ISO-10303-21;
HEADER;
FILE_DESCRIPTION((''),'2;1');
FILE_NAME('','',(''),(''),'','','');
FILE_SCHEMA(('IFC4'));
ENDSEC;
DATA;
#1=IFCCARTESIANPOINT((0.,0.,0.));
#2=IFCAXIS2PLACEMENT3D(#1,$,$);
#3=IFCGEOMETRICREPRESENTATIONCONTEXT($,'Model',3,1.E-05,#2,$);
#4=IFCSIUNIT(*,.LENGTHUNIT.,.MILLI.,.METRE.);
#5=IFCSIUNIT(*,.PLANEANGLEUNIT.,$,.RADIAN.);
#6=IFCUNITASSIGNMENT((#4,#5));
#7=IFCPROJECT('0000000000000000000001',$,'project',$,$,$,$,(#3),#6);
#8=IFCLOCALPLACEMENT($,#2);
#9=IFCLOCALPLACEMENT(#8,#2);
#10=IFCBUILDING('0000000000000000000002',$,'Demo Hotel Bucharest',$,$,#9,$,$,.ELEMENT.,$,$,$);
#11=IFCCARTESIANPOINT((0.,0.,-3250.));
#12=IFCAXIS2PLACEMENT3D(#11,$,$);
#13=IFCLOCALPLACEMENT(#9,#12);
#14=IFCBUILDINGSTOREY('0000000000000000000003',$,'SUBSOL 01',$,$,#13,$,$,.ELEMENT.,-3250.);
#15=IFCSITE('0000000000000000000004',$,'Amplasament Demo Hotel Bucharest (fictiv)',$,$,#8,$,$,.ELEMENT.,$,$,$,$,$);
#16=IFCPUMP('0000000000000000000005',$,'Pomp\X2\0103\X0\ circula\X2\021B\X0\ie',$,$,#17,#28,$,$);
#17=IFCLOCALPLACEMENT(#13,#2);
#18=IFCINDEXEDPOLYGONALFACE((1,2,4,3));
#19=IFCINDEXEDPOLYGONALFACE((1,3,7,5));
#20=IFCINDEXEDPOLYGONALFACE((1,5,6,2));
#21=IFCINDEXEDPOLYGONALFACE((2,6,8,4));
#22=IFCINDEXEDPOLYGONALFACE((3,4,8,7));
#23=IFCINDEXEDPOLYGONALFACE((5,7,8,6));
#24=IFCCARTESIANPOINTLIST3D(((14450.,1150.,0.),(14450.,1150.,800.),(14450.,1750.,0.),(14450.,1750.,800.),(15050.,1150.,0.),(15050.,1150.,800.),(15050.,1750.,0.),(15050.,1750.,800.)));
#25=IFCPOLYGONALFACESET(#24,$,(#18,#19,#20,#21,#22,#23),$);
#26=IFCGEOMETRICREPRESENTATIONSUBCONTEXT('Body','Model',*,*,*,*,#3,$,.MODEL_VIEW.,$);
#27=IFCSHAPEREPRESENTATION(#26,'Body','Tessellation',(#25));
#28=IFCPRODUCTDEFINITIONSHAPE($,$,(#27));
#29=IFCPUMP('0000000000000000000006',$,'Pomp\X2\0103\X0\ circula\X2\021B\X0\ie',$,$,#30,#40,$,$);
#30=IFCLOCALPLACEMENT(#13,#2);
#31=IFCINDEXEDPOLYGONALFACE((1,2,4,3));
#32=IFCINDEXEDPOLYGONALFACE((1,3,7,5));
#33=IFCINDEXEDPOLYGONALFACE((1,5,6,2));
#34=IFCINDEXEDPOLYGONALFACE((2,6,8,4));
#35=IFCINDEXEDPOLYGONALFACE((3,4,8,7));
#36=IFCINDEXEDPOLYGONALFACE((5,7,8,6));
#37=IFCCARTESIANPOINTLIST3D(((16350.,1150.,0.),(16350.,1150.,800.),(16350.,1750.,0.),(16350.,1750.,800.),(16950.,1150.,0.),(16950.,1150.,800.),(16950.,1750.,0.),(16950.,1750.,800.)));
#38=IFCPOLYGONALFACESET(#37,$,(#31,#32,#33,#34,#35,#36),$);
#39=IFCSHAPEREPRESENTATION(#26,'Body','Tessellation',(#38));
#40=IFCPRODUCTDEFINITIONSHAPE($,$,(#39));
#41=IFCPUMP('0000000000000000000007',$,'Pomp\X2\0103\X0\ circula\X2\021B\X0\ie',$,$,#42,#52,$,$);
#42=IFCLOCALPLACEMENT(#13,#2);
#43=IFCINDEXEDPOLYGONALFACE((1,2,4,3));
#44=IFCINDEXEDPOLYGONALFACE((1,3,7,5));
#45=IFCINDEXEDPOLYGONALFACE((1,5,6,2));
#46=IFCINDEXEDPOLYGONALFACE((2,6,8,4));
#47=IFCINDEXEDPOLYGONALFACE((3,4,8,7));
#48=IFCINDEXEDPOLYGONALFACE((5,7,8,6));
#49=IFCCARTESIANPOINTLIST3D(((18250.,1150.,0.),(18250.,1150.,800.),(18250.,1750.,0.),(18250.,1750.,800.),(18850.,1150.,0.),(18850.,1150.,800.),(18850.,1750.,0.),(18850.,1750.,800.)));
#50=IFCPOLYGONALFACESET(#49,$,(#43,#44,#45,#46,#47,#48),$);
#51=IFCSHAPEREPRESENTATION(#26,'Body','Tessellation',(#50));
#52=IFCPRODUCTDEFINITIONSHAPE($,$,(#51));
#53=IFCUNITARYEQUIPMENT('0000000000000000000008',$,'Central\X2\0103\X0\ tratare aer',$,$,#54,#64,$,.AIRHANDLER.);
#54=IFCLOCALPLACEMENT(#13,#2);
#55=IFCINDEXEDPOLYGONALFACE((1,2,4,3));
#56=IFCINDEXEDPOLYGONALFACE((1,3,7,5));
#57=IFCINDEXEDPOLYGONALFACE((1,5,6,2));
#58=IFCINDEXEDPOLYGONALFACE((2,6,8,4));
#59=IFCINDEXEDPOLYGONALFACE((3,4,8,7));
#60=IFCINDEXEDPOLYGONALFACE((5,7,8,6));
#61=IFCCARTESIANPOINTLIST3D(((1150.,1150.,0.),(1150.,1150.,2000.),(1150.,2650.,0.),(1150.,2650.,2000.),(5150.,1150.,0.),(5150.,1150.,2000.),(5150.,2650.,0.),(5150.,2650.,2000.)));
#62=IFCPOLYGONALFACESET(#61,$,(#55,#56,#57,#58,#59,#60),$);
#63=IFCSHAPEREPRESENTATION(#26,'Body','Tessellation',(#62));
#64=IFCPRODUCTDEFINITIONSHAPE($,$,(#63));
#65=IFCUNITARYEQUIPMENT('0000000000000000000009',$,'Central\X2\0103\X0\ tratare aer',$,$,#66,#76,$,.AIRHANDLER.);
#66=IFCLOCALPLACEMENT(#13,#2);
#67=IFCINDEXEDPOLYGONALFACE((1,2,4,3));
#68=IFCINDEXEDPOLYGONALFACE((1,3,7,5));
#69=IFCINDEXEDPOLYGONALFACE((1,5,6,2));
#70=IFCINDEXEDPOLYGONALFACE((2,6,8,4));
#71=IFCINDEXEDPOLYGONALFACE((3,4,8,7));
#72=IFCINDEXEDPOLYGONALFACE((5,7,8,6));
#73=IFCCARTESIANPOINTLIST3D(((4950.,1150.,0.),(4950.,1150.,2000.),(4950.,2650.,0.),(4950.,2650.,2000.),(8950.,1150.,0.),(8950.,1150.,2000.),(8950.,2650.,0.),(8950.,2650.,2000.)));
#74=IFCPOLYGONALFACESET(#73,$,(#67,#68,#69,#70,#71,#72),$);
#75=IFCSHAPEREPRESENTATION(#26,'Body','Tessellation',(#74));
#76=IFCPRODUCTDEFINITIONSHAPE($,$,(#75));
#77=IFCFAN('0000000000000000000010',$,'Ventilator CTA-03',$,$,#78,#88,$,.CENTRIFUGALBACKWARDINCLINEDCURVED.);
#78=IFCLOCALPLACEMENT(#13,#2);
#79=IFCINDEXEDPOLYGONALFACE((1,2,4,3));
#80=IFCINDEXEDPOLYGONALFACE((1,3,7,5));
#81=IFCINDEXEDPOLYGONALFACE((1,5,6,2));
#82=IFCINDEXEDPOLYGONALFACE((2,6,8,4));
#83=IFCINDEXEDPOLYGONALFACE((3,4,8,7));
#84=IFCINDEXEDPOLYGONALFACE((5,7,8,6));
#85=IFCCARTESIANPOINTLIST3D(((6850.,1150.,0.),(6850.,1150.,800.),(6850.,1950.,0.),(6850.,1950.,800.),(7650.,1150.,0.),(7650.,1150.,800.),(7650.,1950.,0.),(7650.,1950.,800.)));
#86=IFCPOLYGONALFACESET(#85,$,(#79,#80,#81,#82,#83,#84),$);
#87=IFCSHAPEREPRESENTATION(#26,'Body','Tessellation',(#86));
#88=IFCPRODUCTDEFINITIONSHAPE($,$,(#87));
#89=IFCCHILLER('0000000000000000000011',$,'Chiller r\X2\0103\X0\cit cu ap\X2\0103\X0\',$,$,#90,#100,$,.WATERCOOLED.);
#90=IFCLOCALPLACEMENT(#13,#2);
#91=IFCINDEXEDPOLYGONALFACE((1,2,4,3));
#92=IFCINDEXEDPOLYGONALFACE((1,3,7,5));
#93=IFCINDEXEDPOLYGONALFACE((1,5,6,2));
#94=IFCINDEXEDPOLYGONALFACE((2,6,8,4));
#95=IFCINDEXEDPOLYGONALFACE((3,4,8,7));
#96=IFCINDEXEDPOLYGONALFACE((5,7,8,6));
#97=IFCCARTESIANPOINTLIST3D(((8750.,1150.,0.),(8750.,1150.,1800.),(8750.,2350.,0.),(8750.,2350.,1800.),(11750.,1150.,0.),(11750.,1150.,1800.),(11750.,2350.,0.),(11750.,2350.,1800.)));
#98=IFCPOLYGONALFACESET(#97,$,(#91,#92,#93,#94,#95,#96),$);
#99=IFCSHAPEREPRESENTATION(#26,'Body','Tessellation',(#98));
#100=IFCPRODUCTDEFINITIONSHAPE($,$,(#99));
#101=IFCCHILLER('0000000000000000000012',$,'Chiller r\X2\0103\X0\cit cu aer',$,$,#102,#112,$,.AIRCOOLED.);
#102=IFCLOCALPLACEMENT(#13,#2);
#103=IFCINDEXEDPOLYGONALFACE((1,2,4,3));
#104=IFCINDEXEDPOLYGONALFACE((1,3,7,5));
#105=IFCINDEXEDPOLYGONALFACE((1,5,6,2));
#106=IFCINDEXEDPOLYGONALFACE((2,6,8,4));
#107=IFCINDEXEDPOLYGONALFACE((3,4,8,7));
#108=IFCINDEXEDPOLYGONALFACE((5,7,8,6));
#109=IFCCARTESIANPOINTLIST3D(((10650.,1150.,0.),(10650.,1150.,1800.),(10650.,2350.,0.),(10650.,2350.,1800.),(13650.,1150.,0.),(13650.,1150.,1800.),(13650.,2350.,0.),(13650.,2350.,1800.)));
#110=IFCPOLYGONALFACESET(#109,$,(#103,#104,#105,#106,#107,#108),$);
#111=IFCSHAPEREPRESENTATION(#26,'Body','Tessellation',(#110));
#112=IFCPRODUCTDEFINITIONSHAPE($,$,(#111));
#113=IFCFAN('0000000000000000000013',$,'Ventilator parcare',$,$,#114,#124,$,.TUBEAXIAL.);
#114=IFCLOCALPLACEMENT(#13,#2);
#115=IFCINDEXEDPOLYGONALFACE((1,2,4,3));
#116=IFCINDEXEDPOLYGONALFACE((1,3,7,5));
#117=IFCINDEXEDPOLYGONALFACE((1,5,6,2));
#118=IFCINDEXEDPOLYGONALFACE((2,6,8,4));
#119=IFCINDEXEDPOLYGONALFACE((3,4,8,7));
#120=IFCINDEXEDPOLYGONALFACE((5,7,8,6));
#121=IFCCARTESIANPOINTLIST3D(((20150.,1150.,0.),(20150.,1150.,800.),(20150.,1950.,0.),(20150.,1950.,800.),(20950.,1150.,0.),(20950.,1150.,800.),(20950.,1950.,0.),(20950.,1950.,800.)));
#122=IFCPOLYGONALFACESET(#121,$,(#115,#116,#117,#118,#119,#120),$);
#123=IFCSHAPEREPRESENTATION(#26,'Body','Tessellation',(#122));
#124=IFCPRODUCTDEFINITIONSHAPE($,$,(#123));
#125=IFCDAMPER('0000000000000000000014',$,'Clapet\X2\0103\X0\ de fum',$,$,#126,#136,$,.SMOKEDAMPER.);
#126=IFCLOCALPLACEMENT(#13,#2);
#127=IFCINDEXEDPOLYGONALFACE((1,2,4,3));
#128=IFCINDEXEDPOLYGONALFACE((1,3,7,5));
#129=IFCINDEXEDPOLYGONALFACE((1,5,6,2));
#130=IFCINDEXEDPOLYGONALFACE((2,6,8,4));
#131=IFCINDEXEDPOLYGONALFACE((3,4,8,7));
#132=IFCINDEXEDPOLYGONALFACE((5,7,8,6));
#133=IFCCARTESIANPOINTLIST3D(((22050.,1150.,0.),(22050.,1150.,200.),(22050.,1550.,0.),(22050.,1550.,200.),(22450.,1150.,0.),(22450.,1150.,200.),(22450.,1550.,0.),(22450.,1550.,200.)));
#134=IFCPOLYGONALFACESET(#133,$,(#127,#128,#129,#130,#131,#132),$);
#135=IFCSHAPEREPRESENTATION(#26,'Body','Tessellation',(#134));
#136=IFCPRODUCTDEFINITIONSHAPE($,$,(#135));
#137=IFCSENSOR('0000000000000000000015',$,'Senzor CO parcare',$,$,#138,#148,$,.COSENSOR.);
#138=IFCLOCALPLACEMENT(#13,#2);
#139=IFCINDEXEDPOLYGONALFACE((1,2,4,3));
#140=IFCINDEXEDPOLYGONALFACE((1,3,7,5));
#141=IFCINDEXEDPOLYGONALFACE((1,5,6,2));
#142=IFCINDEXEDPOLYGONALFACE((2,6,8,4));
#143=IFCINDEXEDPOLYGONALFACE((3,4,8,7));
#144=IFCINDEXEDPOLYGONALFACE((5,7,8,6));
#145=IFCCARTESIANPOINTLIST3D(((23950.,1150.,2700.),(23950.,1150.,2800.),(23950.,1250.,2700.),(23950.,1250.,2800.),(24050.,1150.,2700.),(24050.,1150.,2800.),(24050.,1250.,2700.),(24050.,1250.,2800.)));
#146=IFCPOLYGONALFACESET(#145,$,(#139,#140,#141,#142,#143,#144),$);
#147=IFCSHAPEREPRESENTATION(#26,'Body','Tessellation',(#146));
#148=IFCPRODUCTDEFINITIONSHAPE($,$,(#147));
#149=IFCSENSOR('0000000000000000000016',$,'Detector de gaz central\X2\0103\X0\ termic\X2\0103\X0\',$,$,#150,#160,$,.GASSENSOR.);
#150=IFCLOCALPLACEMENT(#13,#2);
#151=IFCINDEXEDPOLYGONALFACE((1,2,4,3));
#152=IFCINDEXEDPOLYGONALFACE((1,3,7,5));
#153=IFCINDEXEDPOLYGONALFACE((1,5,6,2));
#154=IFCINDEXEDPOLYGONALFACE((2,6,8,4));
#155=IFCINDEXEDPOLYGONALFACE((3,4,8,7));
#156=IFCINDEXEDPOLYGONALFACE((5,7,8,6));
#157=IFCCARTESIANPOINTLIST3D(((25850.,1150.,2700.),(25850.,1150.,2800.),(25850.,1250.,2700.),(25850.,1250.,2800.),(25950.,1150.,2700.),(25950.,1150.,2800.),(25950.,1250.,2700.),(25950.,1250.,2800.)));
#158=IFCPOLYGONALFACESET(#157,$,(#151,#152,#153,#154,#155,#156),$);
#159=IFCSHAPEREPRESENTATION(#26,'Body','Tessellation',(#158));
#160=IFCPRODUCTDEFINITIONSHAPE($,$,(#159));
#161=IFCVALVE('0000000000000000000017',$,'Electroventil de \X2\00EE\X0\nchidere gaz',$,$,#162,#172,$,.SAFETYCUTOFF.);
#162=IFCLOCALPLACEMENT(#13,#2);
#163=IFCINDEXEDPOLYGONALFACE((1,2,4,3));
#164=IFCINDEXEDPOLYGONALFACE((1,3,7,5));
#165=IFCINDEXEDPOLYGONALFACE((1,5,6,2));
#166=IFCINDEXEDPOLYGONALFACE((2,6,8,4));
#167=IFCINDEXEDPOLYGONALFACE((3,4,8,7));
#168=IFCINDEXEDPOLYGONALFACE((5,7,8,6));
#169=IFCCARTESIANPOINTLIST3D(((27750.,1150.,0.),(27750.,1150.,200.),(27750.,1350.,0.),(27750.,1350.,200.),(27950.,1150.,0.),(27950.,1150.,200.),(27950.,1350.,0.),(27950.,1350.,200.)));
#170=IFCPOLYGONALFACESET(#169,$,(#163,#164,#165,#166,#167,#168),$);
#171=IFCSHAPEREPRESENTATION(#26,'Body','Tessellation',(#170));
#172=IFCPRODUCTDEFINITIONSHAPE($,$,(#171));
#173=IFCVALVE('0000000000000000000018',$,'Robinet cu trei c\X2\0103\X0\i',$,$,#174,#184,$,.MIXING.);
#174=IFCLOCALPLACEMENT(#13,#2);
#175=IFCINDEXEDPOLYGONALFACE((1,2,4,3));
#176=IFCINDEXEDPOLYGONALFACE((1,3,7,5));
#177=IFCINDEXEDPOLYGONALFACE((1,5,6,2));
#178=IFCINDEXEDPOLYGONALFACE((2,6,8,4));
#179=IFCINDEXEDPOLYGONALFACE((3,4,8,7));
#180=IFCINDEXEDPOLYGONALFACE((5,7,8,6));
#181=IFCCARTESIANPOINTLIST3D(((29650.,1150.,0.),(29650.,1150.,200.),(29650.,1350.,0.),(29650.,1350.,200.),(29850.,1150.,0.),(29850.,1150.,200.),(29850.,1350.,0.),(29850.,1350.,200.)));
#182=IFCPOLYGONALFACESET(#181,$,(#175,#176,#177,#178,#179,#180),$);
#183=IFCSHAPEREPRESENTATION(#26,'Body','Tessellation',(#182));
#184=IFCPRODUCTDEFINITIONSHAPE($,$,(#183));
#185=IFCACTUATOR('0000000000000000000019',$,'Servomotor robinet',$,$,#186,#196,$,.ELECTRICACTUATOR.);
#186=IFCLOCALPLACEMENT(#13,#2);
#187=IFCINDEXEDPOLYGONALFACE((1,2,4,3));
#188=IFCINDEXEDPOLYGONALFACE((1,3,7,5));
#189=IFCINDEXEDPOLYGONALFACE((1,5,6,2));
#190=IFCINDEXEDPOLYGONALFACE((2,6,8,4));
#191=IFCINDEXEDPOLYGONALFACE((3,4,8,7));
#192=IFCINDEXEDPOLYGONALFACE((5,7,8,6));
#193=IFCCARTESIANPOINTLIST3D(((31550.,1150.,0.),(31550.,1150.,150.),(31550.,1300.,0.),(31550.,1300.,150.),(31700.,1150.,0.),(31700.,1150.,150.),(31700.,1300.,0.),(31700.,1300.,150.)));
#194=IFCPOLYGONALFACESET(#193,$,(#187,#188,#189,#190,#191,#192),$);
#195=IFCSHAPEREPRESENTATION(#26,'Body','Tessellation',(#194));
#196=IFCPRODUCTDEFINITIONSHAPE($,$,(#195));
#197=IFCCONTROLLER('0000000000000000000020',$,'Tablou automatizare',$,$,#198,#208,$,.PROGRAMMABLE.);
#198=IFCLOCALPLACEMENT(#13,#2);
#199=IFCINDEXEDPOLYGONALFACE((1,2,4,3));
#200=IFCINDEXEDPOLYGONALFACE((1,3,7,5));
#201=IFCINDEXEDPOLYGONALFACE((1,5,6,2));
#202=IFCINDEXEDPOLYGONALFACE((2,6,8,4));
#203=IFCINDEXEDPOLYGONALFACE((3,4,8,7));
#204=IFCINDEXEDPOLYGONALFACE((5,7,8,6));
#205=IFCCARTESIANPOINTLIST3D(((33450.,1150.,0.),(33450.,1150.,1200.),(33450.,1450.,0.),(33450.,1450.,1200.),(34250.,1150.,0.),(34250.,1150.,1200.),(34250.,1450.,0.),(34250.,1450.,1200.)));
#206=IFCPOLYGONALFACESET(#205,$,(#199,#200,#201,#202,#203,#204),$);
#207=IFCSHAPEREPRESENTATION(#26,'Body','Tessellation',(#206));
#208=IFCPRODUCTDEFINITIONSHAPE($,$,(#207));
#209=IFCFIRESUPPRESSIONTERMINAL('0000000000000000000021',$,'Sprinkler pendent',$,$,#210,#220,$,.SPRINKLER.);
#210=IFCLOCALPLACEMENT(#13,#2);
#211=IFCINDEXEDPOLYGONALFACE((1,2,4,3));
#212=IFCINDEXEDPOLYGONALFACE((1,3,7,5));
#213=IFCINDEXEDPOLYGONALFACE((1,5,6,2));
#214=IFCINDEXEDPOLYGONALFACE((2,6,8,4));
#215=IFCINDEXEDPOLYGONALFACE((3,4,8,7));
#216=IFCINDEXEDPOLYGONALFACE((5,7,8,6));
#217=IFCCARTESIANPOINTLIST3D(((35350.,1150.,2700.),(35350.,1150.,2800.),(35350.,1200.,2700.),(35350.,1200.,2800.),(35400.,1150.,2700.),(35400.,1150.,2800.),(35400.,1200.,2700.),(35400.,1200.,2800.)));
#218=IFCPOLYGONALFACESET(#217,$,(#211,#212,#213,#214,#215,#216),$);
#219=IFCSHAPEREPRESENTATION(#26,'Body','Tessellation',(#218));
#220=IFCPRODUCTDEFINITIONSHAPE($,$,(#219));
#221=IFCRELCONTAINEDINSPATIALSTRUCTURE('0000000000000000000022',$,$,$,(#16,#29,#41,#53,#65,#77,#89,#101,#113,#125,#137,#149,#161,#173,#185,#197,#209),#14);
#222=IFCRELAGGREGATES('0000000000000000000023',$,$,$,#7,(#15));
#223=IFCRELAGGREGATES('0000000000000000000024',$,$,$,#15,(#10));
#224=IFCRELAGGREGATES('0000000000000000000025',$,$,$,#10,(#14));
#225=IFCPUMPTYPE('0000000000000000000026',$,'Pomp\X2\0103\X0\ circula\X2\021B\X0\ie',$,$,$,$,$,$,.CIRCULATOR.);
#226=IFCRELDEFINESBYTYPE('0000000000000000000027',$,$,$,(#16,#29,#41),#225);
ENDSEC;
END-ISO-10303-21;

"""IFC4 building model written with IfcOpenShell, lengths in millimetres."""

from ifc_helpers import new_model, si_unit, frame, frame_2d, origin, place, context, subcontext, project, spatial, rectangle, extrude, type_object, element, save


model = new_model("IFC4")

# Units and contexts
model_context = context("Model", 3, precision=1e-05, world=origin())
body_context = subcontext(model_context, "Body", "Model", "MODEL_VIEW")
ifc_project = project(units=[si_unit("LENGTHUNIT", "METRE", prefix="MILLI"), si_unit("PLANEANGLEUNIT", "RADIAN")], contexts=[model_context])

# Site, building, storey
site_placement = place(None, origin())
site = spatial("IfcSite", under=ifc_project, at=site_placement, Name="Amplasament Demo Hotel Bucharest (fictiv)", CompositionType="ELEMENT")
building_placement = place(site_placement, origin())
building = spatial("IfcBuilding", under=site, at=building_placement, Name="Demo Hotel Bucharest", CompositionType="ELEMENT")
storey_placement = place(building_placement, frame((0.0, 0.0, -3250.0)))
storey = spatial("IfcBuildingStorey", under=building, at=storey_placement, Name="SUBSOL 01", CompositionType="ELEMENT", Elevation=-3250.0)

# Pumps
pump_type = type_object("IfcPumpType", Name="Pompă circulație", PredefinedType="CIRCULATOR")
for number, where, name in (
    (1, (14450.0, 1150.0, 0.0), "Pompă circulație"),
    (2, (16350.0, 1150.0, 0.0), "Pompă circulație"),
    (3, (18250.0, 1150.0, 0.0), "Pompă circulație"),
):
    element("IfcPump", number, at=place(storey_placement, frame(where)), inside=storey, type_object=pump_type, Name=name, context=body_context, shape_type="SweptSolid", body=[
        extrude(rectangle(XDim=600.0, YDim=600.0, at=frame_2d((300.0, 300.0))), origin(), (0.0, 0.0, 1.0), 800.0),
    ])

# Unitary equipment
for number, where, name in (
    (4, (1150.0, 1150.0, 0.0), "Centrală tratare aer"),
    (5, (4950.0, 1150.0, 0.0), "Centrală tratare aer"),
):
    element("IfcUnitaryEquipment", number, at=place(storey_placement, frame(where)), inside=storey, Name=name, PredefinedType="AIRHANDLER", context=body_context, shape_type="SweptSolid", body=[
        extrude(rectangle(XDim=4000.0, YDim=1500.0, at=frame_2d((2000.0, 750.0))), origin(), (0.0, 0.0, 1.0), 2000.0),
    ])

# Fan
fan_1_placement = place(storey_placement, frame((6850.0, 1150.0, 0.0)))
element("IfcFan", 6, at=fan_1_placement, inside=storey, Name="Ventilator CTA-03", PredefinedType="CENTRIFUGALBACKWARDINCLINEDCURVED", context=body_context, shape_type="SweptSolid", body=[
    extrude(rectangle(XDim=800.0, YDim=800.0, at=frame_2d((400.0, 400.0))), origin(), (0.0, 0.0, 1.0), 800.0),
])

# Chillers
chiller_1_placement = place(storey_placement, frame((8750.0, 1150.0, 0.0)))
element("IfcChiller", 7, at=chiller_1_placement, inside=storey, Name="Chiller răcit cu apă", PredefinedType="WATERCOOLED", context=body_context, shape_type="SweptSolid", body=[
    extrude(rectangle(XDim=3000.0, YDim=1200.0, at=frame_2d((1500.0, 600.0))), origin(), (0.0, 0.0, 1.0), 1800.0),
])
chiller_2_placement = place(storey_placement, frame((10650.0, 1150.0, 0.0)))
element("IfcChiller", 8, at=chiller_2_placement, inside=storey, Name="Chiller răcit cu aer", PredefinedType="AIRCOOLED", context=body_context, shape_type="SweptSolid", body=[
    extrude(rectangle(XDim=3000.0, YDim=1200.0, at=frame_2d((1500.0, 600.0))), origin(), (0.0, 0.0, 1.0), 1800.0),
])

# Fan
fan_2_placement = place(storey_placement, frame((20150.0, 1150.0, 0.0)))
element("IfcFan", 9, at=fan_2_placement, inside=storey, Name="Ventilator parcare", PredefinedType="TUBEAXIAL", context=body_context, shape_type="SweptSolid", body=[
    extrude(rectangle(XDim=800.0, YDim=800.0, at=frame_2d((400.0, 400.0))), origin(), (0.0, 0.0, 1.0), 800.0),
])

# Damper
damper_placement = place(storey_placement, frame((22050.0, 1150.0, 0.0)))
element("IfcDamper", 10, at=damper_placement, inside=storey, Name="Clapetă de fum", PredefinedType="SMOKEDAMPER", context=body_context, shape_type="SweptSolid", body=[
    extrude(rectangle(XDim=400.0, YDim=400.0, at=frame_2d((200.0, 200.0))), origin(), (0.0, 0.0, 1.0), 200.0),
])

# Sensors
sensor_1_placement = place(storey_placement, frame((23950.0, 1150.0, 2700.0)))
element("IfcSensor", 11, at=sensor_1_placement, inside=storey, Name="Senzor CO parcare", PredefinedType="COSENSOR", context=body_context, shape_type="SweptSolid", body=[
    extrude(rectangle(XDim=100.0, YDim=100.0, at=frame_2d((50.0, 50.0))), origin(), (0.0, 0.0, 1.0), 100.0),
])
sensor_2_placement = place(storey_placement, frame((25850.0, 1150.0, 2700.0)))
element("IfcSensor", 12, at=sensor_2_placement, inside=storey, Name="Detector de gaz centrală termică", PredefinedType="GASSENSOR", context=body_context, shape_type="SweptSolid", body=[
    extrude(rectangle(XDim=100.0, YDim=100.0, at=frame_2d((50.0, 50.0))), origin(), (0.0, 0.0, 1.0), 100.0),
])

# Valves
valve_1_placement = place(storey_placement, frame((27750.0, 1150.0, 0.0)))
element("IfcValve", 13, at=valve_1_placement, inside=storey, Name="Electroventil de închidere gaz", PredefinedType="SAFETYCUTOFF", context=body_context, shape_type="SweptSolid", body=[
    extrude(rectangle(XDim=200.0, YDim=200.0, at=frame_2d((100.0, 100.0))), origin(), (0.0, 0.0, 1.0), 200.0),
])
valve_2_placement = place(storey_placement, frame((29650.0, 1150.0, 0.0)))
element("IfcValve", 14, at=valve_2_placement, inside=storey, Name="Robinet cu trei căi", PredefinedType="MIXING", context=body_context, shape_type="SweptSolid", body=[
    extrude(rectangle(XDim=200.0, YDim=200.0, at=frame_2d((100.0, 100.0))), origin(), (0.0, 0.0, 1.0), 200.0),
])

# Actuator
actuator_placement = place(storey_placement, frame((31550.0, 1150.0, 0.0)))
element("IfcActuator", 15, at=actuator_placement, inside=storey, Name="Servomotor robinet", PredefinedType="ELECTRICACTUATOR", context=body_context, shape_type="SweptSolid", body=[
    extrude(rectangle(XDim=150.0, YDim=150.0, at=frame_2d((75.0, 75.0))), origin(), (0.0, 0.0, 1.0), 150.0),
])

# Controller
controller_placement = place(storey_placement, frame((33450.0, 1150.0, 0.0)))
element("IfcController", 16, at=controller_placement, inside=storey, Name="Tablou automatizare", PredefinedType="PROGRAMMABLE", context=body_context, shape_type="SweptSolid", body=[
    extrude(rectangle(XDim=800.0, YDim=300.0, at=frame_2d((400.0, 150.0))), origin(), (0.0, 0.0, 1.0), 1200.0),
])

# Fire suppression terminal
for number, where, name in (
    (17, (35350.0, 1150.0, 2700.0), "Sprinkler pendent"),
):
    element("IfcFireSuppressionTerminal", number, at=place(storey_placement, frame(where)), inside=storey, Name=name, PredefinedType="SPRINKLER", context=body_context, shape_type="SweptSolid", body=[
        extrude(rectangle(XDim=50.0, YDim=50.0, at=frame_2d((25.0, 25.0))), origin(), (0.0, 0.0, 1.0), 100.0),
    ])

save(model, "model.ifc")
